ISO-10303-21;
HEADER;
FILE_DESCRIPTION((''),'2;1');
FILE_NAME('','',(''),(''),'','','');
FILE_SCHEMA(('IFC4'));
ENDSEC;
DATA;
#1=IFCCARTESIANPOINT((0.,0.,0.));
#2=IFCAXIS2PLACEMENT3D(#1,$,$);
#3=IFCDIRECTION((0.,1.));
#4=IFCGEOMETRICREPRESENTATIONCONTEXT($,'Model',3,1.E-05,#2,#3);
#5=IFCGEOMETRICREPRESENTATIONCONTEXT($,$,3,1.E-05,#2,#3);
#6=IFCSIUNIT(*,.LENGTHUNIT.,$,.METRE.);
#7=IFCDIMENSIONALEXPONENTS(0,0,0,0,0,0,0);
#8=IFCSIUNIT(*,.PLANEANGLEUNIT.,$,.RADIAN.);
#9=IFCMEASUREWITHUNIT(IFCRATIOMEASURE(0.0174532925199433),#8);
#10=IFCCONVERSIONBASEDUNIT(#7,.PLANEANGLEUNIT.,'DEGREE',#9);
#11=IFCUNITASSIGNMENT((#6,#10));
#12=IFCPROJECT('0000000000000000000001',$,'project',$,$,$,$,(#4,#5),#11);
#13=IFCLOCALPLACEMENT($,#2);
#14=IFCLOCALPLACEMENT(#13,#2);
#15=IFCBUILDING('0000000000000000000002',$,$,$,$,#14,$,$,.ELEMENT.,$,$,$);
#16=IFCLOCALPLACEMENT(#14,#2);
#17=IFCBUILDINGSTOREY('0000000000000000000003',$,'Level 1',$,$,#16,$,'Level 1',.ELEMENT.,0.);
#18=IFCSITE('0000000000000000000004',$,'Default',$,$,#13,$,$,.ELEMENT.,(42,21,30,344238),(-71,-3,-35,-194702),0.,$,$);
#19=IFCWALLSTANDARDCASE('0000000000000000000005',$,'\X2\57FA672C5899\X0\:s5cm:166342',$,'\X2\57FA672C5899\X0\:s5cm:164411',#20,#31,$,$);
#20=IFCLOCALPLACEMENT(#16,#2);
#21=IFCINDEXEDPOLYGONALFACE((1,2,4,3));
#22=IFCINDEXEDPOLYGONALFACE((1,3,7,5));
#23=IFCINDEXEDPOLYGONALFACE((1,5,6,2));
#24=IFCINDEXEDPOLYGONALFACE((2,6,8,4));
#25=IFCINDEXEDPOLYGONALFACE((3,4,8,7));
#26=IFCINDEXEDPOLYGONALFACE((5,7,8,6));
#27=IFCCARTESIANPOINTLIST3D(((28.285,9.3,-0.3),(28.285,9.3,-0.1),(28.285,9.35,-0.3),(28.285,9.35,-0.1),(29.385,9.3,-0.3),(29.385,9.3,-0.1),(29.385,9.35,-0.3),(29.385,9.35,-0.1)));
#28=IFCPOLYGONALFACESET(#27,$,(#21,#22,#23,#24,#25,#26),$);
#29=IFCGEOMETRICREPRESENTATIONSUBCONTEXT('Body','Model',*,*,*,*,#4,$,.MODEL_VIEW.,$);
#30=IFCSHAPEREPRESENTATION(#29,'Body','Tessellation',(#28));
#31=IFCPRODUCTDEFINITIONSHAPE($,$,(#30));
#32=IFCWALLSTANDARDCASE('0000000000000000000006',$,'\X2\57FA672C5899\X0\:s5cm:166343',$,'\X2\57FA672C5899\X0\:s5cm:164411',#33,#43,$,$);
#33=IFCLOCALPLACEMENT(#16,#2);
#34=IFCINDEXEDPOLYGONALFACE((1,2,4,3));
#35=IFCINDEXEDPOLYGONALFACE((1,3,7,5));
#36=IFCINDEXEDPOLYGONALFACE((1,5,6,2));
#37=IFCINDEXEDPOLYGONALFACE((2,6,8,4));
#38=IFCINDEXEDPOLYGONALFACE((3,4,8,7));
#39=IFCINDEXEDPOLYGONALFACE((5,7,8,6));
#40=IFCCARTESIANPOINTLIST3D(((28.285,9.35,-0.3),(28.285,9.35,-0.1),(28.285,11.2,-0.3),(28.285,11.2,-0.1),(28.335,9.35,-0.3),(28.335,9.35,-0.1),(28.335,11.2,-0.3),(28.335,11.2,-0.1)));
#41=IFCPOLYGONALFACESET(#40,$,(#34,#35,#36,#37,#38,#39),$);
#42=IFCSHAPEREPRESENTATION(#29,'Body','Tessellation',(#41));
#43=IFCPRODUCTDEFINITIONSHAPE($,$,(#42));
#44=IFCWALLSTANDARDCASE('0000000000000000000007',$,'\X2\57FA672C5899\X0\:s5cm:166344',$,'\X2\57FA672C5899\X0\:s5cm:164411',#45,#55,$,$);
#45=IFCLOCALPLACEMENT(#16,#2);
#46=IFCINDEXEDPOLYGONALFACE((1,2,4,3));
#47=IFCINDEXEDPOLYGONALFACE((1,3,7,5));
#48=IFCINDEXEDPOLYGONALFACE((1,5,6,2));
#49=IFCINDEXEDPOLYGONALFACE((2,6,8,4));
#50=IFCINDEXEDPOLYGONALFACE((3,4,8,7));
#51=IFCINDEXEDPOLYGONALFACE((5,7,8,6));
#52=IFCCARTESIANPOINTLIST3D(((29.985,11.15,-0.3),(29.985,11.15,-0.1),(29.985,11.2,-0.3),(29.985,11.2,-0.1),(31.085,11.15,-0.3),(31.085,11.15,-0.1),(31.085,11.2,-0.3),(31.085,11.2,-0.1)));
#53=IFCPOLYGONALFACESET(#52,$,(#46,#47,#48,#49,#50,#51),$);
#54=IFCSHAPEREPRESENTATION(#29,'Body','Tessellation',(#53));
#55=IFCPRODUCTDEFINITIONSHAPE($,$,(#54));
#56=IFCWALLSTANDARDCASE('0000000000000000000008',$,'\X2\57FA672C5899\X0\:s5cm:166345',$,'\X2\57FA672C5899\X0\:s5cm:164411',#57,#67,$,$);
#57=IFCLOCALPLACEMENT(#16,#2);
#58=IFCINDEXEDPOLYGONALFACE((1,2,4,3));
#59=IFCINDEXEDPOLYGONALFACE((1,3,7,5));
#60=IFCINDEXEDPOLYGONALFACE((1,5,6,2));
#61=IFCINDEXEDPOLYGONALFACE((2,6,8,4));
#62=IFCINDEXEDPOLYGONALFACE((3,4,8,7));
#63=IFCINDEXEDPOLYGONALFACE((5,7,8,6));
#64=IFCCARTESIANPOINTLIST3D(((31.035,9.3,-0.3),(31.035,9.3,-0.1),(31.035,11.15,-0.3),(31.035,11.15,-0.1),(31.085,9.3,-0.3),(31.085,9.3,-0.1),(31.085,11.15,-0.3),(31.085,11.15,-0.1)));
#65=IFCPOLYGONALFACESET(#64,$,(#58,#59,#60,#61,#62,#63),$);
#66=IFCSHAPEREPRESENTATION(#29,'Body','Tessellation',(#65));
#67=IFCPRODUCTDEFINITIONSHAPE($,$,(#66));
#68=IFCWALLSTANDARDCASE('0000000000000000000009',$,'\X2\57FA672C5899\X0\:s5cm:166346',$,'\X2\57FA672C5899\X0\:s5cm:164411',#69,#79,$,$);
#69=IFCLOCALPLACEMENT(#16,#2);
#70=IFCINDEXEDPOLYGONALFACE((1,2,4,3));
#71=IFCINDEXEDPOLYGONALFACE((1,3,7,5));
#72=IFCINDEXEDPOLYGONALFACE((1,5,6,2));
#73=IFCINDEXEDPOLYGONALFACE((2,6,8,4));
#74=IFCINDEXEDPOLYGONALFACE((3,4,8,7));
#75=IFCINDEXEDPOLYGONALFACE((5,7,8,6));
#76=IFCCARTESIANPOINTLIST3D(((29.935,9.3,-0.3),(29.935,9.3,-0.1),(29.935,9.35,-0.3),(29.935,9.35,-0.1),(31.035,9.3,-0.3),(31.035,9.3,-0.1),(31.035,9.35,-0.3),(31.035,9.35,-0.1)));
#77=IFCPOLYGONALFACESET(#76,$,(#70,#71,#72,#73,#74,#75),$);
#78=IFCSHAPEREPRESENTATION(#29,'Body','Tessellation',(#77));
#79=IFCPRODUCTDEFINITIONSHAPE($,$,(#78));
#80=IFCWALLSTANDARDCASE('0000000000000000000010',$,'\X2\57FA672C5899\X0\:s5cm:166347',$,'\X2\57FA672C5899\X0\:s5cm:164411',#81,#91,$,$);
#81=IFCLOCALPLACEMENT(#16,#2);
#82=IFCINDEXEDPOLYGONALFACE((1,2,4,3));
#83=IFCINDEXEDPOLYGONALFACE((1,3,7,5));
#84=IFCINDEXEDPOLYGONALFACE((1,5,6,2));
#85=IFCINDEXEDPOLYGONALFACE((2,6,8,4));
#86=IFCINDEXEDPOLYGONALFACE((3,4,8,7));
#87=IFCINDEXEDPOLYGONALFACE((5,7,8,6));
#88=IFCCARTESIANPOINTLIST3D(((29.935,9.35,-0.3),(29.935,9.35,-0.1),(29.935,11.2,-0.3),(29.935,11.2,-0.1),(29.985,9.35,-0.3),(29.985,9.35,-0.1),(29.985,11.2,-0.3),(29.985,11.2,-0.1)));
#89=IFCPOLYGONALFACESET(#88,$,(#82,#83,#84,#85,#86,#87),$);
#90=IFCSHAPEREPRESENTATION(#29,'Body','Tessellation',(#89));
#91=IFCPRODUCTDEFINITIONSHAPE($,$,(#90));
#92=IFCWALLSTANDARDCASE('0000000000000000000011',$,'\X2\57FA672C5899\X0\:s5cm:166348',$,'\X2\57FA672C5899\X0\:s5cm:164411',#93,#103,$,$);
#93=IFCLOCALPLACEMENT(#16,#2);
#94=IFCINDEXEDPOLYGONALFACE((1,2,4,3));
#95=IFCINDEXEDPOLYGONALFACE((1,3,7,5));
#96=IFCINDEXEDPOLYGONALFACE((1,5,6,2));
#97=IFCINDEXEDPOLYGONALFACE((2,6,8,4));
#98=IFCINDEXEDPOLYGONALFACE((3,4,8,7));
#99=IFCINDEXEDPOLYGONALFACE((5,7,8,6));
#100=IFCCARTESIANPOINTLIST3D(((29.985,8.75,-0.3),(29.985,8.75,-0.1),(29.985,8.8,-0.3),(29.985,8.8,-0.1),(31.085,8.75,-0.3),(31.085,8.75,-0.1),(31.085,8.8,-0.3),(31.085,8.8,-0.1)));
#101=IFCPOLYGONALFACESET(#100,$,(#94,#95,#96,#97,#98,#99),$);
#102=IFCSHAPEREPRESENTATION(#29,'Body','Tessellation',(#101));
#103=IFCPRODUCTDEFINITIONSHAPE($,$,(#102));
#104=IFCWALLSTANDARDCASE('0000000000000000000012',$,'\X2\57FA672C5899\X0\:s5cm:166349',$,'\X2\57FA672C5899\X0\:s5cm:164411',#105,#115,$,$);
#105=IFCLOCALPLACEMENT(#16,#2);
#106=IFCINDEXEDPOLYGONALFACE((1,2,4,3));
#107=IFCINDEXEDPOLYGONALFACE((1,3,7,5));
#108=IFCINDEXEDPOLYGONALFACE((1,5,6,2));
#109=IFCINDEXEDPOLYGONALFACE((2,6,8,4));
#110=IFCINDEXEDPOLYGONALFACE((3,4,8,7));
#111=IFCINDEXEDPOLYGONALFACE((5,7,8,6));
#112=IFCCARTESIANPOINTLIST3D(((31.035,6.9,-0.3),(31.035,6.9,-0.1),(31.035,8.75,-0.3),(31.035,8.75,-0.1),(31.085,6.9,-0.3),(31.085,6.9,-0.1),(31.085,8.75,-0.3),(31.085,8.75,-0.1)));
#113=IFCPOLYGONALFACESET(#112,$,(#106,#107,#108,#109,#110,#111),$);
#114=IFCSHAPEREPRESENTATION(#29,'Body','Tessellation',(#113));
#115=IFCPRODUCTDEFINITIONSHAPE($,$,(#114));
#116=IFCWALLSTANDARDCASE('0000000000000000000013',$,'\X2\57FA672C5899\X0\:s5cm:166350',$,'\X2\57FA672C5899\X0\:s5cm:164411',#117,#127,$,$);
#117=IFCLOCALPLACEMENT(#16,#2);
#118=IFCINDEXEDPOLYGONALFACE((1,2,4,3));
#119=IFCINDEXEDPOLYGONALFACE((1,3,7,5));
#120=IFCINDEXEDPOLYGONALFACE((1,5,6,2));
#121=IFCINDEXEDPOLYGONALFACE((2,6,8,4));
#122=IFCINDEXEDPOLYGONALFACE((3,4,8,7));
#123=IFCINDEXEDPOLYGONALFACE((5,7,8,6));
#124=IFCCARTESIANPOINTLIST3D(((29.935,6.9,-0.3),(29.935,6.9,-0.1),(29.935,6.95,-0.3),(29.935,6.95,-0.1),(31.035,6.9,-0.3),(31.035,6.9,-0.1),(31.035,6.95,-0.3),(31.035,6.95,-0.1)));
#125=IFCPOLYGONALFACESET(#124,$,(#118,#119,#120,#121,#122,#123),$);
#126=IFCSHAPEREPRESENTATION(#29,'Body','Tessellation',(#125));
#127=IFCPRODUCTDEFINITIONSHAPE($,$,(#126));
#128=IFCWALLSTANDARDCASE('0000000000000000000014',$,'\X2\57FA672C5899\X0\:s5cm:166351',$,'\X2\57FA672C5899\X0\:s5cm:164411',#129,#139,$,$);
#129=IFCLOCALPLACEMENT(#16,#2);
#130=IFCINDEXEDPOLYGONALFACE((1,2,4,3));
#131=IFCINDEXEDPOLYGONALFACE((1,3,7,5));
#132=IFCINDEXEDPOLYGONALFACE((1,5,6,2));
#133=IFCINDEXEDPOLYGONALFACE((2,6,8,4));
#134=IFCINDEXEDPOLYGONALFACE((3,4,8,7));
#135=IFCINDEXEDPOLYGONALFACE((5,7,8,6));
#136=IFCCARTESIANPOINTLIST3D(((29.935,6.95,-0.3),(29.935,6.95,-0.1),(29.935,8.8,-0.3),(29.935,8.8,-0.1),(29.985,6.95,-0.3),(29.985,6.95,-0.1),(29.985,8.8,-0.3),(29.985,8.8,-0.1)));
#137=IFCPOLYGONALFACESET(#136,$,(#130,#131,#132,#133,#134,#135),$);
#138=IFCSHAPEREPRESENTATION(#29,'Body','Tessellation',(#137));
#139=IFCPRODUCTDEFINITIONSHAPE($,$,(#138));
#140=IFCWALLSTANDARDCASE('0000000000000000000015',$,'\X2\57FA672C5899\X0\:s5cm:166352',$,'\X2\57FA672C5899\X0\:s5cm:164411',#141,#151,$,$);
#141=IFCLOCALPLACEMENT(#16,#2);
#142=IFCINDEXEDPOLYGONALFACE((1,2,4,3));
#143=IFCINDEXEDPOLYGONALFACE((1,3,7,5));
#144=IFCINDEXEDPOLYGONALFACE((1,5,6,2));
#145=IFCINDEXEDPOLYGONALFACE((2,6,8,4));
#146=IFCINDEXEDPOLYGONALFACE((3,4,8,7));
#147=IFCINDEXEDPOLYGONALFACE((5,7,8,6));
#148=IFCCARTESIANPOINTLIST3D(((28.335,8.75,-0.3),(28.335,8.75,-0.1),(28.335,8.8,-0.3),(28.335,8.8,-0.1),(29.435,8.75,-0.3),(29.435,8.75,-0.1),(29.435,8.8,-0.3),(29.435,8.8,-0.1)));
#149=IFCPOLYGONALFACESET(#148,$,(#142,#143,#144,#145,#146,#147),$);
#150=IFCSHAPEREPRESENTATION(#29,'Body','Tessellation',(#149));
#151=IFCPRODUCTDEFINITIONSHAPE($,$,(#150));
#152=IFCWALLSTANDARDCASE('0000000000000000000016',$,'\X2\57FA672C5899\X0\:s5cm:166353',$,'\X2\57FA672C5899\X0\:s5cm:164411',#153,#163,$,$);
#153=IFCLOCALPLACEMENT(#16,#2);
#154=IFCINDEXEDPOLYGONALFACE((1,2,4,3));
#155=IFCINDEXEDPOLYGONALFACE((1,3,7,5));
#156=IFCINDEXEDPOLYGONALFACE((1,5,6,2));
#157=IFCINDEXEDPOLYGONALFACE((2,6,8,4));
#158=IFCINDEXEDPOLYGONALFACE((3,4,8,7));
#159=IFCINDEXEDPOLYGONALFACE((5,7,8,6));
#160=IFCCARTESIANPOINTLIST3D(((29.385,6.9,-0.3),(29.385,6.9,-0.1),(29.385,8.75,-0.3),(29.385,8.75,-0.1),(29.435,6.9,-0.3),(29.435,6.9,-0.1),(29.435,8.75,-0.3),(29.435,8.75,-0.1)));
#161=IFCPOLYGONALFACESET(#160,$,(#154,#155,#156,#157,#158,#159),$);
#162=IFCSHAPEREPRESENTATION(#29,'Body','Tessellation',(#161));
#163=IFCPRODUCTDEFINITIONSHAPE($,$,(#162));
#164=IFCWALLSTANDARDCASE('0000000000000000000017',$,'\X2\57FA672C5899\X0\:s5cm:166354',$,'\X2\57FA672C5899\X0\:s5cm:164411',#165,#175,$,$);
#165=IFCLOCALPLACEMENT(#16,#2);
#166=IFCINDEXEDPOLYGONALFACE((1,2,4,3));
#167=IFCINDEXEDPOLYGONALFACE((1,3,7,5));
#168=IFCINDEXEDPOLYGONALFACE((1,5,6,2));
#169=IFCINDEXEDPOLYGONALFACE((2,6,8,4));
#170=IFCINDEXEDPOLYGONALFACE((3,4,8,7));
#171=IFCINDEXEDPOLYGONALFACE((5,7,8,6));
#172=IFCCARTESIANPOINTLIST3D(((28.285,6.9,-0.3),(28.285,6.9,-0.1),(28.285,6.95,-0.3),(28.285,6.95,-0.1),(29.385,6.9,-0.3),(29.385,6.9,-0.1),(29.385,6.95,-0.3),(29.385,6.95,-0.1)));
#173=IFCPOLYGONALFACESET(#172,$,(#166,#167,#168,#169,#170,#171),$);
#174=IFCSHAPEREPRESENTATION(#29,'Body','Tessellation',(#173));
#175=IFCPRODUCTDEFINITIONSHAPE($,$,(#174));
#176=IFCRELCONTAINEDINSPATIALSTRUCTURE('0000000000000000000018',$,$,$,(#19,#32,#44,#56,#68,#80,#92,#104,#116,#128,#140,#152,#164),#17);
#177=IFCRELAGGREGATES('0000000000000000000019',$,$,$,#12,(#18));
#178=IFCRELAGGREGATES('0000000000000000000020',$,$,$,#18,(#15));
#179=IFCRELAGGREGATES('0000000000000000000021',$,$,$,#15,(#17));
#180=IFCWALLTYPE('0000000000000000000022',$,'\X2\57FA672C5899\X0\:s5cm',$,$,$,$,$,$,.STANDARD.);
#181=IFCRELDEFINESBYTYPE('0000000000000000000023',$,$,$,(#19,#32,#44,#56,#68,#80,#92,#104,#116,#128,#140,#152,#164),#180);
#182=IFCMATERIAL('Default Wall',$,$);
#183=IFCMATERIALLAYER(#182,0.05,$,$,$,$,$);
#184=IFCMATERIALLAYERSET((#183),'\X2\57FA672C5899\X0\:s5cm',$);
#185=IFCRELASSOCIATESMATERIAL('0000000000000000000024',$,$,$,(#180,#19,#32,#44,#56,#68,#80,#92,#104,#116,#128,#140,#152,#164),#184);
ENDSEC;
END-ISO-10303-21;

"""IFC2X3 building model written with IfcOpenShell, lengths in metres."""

from ifc_helpers import new_model, entity, si_unit, converted_unit, direction, frame, frame_2d, origin, place, context, subcontext, project, spatial, rectangle, extrude, material, layer, layer_set, layer_usage, type_object, element, save


model = new_model("IFC2X3")

# Units and contexts
model_context = context("Model", 3, precision=1e-05, world=origin(), true_north=direction((0.0, 1.0)))
context_of_model = context(None, 3, precision=1e-05, world=origin(), true_north=direction((0.0, 1.0)))
body_context = subcontext(model_context, "Body", "Model", "MODEL_VIEW")
ifc_project = project(units=[si_unit("LENGTHUNIT", "METRE"), converted_unit("PLANEANGLEUNIT", "DEGREE", entity("IfcRatioMeasure", 0.0174532925199433), si_unit("PLANEANGLEUNIT", "RADIAN"), dimensions=[0, 0, 0, 0, 0, 0, 0])], contexts=[model_context, context_of_model])

# Site, building, storey
site_placement = place(None, origin())
site = spatial("IfcSite", under=ifc_project, at=site_placement, Name="Default", CompositionType="ELEMENT", RefLatitude=(42, 21, 30, 344238), RefLongitude=(-71, -3, -35, -194702), RefElevation=0.0)
building_placement = place(site_placement, origin())
building = spatial("IfcBuilding", under=site, at=building_placement, CompositionType="ELEMENT")
storey_placement = place(building_placement, origin())
storey = spatial("IfcBuildingStorey", under=building, at=storey_placement, Name="Level 1", LongName="Level 1", CompositionType="ELEMENT", Elevation=0.0)

# Shared definitions
ifc_material = material(Name="Default Wall")

# Walls
ifc_layer_1 = layer(ifc_material, 0.05)
ifc_layer_set_1 = layer_set([ifc_layer_1], Name="基本墙:s5cm")
wall_type_1 = type_object("IfcWallType", Name="基本墙:s5cm", PredefinedType="STANDARD", material=ifc_layer_set_1)
ifc_layer_usage_1 = layer_usage(ifc_layer_set_1, "AXIS2", "POSITIVE", -0.025)
wall_1_placement = place(storey_placement, frame((29.385, 9.325, -0.3), z_axis=(0.0, 0.0, 1.0), x_axis=(-1.0, 0.0, 0.0)))
element("IfcWallStandardCase", 1, at=wall_1_placement, inside=storey, type_object=wall_type_1, material=ifc_layer_usage_1, Name="基本墙:s5cm:166342", ObjectType="基本墙:s5cm:164411", context=body_context, shape_type="SweptSolid", body=[
    extrude(rectangle(XDim=1.1, YDim=0.05, at=frame_2d((0.55, 0.0), x_axis=(-1.0, 0.0))), origin(), (0.0, 0.0, 1.0), 0.2),
])
ifc_layer_usage_2 = layer_usage(ifc_layer_set_1, "AXIS2", "POSITIVE", -0.025)
wall_2_placement = place(storey_placement, frame((28.31, 9.35, -0.3), z_axis=(0.0, 0.0, 1.0), x_axis=(0.0, 1.0, 0.0)))
element("IfcWallStandardCase", 2, at=wall_2_placement, inside=storey, type_object=wall_type_1, material=ifc_layer_usage_2, Name="基本墙:s5cm:166343", ObjectType="基本墙:s5cm:164411", context=body_context, shape_type="SweptSolid", body=[
    extrude(rectangle(XDim=1.85, YDim=0.05, at=frame_2d((0.925, 0.0), x_axis=(-1.0, 0.0))), origin(), (0.0, 0.0, 1.0), 0.2),
])
ifc_layer_usage_3 = layer_usage(ifc_layer_set_1, "AXIS2", "POSITIVE", -0.025)
wall_3_placement = place(storey_placement, frame((29.985, 11.175, -0.3)))
element("IfcWallStandardCase", 3, at=wall_3_placement, inside=storey, type_object=wall_type_1, material=ifc_layer_usage_3, Name="基本墙:s5cm:166344", ObjectType="基本墙:s5cm:164411", context=body_context, shape_type="SweptSolid", body=[
    extrude(rectangle(XDim=1.1, YDim=0.05, at=frame_2d((0.55, 0.0), x_axis=(-1.0, 0.0))), origin(), (0.0, 0.0, 1.0), 0.2),
])
ifc_layer_usage_4 = layer_usage(ifc_layer_set_1, "AXIS2", "POSITIVE", -0.025)
wall_4_placement = place(storey_placement, frame((31.06, 11.15, -0.3), z_axis=(0.0, 0.0, 1.0), x_axis=(0.0, -1.0, 0.0)))
element("IfcWallStandardCase", 4, at=wall_4_placement, inside=storey, type_object=wall_type_1, material=ifc_layer_usage_4, Name="基本墙:s5cm:166345", ObjectType="基本墙:s5cm:164411", context=body_context, shape_type="SweptSolid", body=[
    extrude(rectangle(XDim=1.85, YDim=0.05, at=frame_2d((0.925, 0.0), x_axis=(-1.0, 0.0))), origin(), (0.0, 0.0, 1.0), 0.2),
])
ifc_layer_usage_5 = layer_usage(ifc_layer_set_1, "AXIS2", "POSITIVE", -0.025)
wall_5_placement = place(storey_placement, frame((31.035, 9.325, -0.3), z_axis=(0.0, 0.0, 1.0), x_axis=(-1.0, 0.0, 0.0)))
element("IfcWallStandardCase", 5, at=wall_5_placement, inside=storey, type_object=wall_type_1, material=ifc_layer_usage_5, Name="基本墙:s5cm:166346", ObjectType="基本墙:s5cm:164411", context=body_context, shape_type="SweptSolid", body=[
    extrude(rectangle(XDim=1.1, YDim=0.05, at=frame_2d((0.55, 0.0), x_axis=(-1.0, 0.0))), origin(), (0.0, 0.0, 1.0), 0.2),
])
ifc_layer_usage_6 = layer_usage(ifc_layer_set_1, "AXIS2", "POSITIVE", -0.025)
wall_6_placement = place(storey_placement, frame((29.96, 9.35, -0.3), z_axis=(0.0, 0.0, 1.0), x_axis=(0.0, 1.0, 0.0)))
element("IfcWallStandardCase", 6, at=wall_6_placement, inside=storey, type_object=wall_type_1, material=ifc_layer_usage_6, Name="基本墙:s5cm:166347", ObjectType="基本墙:s5cm:164411", context=body_context, shape_type="SweptSolid", body=[
    extrude(rectangle(XDim=1.85, YDim=0.05, at=frame_2d((0.925, 0.0), x_axis=(-1.0, 0.0))), origin(), (0.0, 0.0, 1.0), 0.2),
])
ifc_layer_usage_7 = layer_usage(ifc_layer_set_1, "AXIS2", "POSITIVE", -0.025)
wall_7_placement = place(storey_placement, frame((29.985, 8.775, -0.3)))
element("IfcWallStandardCase", 7, at=wall_7_placement, inside=storey, type_object=wall_type_1, material=ifc_layer_usage_7, Name="基本墙:s5cm:166348", ObjectType="基本墙:s5cm:164411", context=body_context, shape_type="SweptSolid", body=[
    extrude(rectangle(XDim=1.1, YDim=0.05, at=frame_2d((0.55, 0.0), x_axis=(-1.0, 0.0))), origin(), (0.0, 0.0, 1.0), 0.2),
])
ifc_layer_usage_8 = layer_usage(ifc_layer_set_1, "AXIS2", "POSITIVE", -0.025)
wall_8_placement = place(storey_placement, frame((31.06, 8.75, -0.3), z_axis=(0.0, 0.0, 1.0), x_axis=(0.0, -1.0, 0.0)))
element("IfcWallStandardCase", 8, at=wall_8_placement, inside=storey, type_object=wall_type_1, material=ifc_layer_usage_8, Name="基本墙:s5cm:166349", ObjectType="基本墙:s5cm:164411", context=body_context, shape_type="SweptSolid", body=[
    extrude(rectangle(XDim=1.85, YDim=0.05, at=frame_2d((0.925, 0.0), x_axis=(-1.0, 0.0))), origin(), (0.0, 0.0, 1.0), 0.2),
])
ifc_layer_usage_9 = layer_usage(ifc_layer_set_1, "AXIS2", "POSITIVE", -0.025)
wall_9_placement = place(storey_placement, frame((31.035, 6.925, -0.3), z_axis=(0.0, 0.0, 1.0), x_axis=(-1.0, 0.0, 0.0)))
element("IfcWallStandardCase", 9, at=wall_9_placement, inside=storey, type_object=wall_type_1, material=ifc_layer_usage_9, Name="基本墙:s5cm:166350", ObjectType="基本墙:s5cm:164411", context=body_context, shape_type="SweptSolid", body=[
    extrude(rectangle(XDim=1.1, YDim=0.05, at=frame_2d((0.55, 0.0), x_axis=(-1.0, 0.0))), origin(), (0.0, 0.0, 1.0), 0.2),
])
ifc_layer_usage_10 = layer_usage(ifc_layer_set_1, "AXIS2", "POSITIVE", -0.025)
wall_10_placement = place(storey_placement, frame((29.96, 6.95, -0.3), z_axis=(0.0, 0.0, 1.0), x_axis=(0.0, 1.0, 0.0)))
element("IfcWallStandardCase", 10, at=wall_10_placement, inside=storey, type_object=wall_type_1, material=ifc_layer_usage_10, Name="基本墙:s5cm:166351", ObjectType="基本墙:s5cm:164411", context=body_context, shape_type="SweptSolid", body=[
    extrude(rectangle(XDim=1.85, YDim=0.05, at=frame_2d((0.925, 0.0), x_axis=(-1.0, 0.0))), origin(), (0.0, 0.0, 1.0), 0.2),
])
ifc_layer_usage_11 = layer_usage(ifc_layer_set_1, "AXIS2", "POSITIVE", -0.025)
wall_11_placement = place(storey_placement, frame((28.335, 8.775, -0.3)))
element("IfcWallStandardCase", 11, at=wall_11_placement, inside=storey, type_object=wall_type_1, material=ifc_layer_usage_11, Name="基本墙:s5cm:166352", ObjectType="基本墙:s5cm:164411", context=body_context, shape_type="SweptSolid", body=[
    extrude(rectangle(XDim=1.1, YDim=0.05, at=frame_2d((0.55, 0.0), x_axis=(-1.0, 0.0))), origin(), (0.0, 0.0, 1.0), 0.2),
])
ifc_layer_usage_12 = layer_usage(ifc_layer_set_1, "AXIS2", "POSITIVE", -0.025)
wall_12_placement = place(storey_placement, frame((29.41, 8.75, -0.3), z_axis=(0.0, 0.0, 1.0), x_axis=(0.0, -1.0, 0.0)))
element("IfcWallStandardCase", 12, at=wall_12_placement, inside=storey, type_object=wall_type_1, material=ifc_layer_usage_12, Name="基本墙:s5cm:166353", ObjectType="基本墙:s5cm:164411", context=body_context, shape_type="SweptSolid", body=[
    extrude(rectangle(XDim=1.85, YDim=0.05, at=frame_2d((0.925, 0.0), x_axis=(-1.0, 0.0))), origin(), (0.0, 0.0, 1.0), 0.2),
])
ifc_layer_usage_13 = layer_usage(ifc_layer_set_1, "AXIS2", "POSITIVE", -0.025)
wall_13_placement = place(storey_placement, frame((29.385, 6.925, -0.3), z_axis=(0.0, 0.0, 1.0), x_axis=(-1.0, 0.0, 0.0)))
element("IfcWallStandardCase", 13, at=wall_13_placement, inside=storey, type_object=wall_type_1, material=ifc_layer_usage_13, Name="基本墙:s5cm:166354", ObjectType="基本墙:s5cm:164411", context=body_context, shape_type="SweptSolid", body=[
    extrude(rectangle(XDim=1.1, YDim=0.05, at=frame_2d((0.55, 0.0), x_axis=(-1.0, 0.0))), origin(), (0.0, 0.0, 1.0), 0.2),
])

save(model, "model.ifc")
